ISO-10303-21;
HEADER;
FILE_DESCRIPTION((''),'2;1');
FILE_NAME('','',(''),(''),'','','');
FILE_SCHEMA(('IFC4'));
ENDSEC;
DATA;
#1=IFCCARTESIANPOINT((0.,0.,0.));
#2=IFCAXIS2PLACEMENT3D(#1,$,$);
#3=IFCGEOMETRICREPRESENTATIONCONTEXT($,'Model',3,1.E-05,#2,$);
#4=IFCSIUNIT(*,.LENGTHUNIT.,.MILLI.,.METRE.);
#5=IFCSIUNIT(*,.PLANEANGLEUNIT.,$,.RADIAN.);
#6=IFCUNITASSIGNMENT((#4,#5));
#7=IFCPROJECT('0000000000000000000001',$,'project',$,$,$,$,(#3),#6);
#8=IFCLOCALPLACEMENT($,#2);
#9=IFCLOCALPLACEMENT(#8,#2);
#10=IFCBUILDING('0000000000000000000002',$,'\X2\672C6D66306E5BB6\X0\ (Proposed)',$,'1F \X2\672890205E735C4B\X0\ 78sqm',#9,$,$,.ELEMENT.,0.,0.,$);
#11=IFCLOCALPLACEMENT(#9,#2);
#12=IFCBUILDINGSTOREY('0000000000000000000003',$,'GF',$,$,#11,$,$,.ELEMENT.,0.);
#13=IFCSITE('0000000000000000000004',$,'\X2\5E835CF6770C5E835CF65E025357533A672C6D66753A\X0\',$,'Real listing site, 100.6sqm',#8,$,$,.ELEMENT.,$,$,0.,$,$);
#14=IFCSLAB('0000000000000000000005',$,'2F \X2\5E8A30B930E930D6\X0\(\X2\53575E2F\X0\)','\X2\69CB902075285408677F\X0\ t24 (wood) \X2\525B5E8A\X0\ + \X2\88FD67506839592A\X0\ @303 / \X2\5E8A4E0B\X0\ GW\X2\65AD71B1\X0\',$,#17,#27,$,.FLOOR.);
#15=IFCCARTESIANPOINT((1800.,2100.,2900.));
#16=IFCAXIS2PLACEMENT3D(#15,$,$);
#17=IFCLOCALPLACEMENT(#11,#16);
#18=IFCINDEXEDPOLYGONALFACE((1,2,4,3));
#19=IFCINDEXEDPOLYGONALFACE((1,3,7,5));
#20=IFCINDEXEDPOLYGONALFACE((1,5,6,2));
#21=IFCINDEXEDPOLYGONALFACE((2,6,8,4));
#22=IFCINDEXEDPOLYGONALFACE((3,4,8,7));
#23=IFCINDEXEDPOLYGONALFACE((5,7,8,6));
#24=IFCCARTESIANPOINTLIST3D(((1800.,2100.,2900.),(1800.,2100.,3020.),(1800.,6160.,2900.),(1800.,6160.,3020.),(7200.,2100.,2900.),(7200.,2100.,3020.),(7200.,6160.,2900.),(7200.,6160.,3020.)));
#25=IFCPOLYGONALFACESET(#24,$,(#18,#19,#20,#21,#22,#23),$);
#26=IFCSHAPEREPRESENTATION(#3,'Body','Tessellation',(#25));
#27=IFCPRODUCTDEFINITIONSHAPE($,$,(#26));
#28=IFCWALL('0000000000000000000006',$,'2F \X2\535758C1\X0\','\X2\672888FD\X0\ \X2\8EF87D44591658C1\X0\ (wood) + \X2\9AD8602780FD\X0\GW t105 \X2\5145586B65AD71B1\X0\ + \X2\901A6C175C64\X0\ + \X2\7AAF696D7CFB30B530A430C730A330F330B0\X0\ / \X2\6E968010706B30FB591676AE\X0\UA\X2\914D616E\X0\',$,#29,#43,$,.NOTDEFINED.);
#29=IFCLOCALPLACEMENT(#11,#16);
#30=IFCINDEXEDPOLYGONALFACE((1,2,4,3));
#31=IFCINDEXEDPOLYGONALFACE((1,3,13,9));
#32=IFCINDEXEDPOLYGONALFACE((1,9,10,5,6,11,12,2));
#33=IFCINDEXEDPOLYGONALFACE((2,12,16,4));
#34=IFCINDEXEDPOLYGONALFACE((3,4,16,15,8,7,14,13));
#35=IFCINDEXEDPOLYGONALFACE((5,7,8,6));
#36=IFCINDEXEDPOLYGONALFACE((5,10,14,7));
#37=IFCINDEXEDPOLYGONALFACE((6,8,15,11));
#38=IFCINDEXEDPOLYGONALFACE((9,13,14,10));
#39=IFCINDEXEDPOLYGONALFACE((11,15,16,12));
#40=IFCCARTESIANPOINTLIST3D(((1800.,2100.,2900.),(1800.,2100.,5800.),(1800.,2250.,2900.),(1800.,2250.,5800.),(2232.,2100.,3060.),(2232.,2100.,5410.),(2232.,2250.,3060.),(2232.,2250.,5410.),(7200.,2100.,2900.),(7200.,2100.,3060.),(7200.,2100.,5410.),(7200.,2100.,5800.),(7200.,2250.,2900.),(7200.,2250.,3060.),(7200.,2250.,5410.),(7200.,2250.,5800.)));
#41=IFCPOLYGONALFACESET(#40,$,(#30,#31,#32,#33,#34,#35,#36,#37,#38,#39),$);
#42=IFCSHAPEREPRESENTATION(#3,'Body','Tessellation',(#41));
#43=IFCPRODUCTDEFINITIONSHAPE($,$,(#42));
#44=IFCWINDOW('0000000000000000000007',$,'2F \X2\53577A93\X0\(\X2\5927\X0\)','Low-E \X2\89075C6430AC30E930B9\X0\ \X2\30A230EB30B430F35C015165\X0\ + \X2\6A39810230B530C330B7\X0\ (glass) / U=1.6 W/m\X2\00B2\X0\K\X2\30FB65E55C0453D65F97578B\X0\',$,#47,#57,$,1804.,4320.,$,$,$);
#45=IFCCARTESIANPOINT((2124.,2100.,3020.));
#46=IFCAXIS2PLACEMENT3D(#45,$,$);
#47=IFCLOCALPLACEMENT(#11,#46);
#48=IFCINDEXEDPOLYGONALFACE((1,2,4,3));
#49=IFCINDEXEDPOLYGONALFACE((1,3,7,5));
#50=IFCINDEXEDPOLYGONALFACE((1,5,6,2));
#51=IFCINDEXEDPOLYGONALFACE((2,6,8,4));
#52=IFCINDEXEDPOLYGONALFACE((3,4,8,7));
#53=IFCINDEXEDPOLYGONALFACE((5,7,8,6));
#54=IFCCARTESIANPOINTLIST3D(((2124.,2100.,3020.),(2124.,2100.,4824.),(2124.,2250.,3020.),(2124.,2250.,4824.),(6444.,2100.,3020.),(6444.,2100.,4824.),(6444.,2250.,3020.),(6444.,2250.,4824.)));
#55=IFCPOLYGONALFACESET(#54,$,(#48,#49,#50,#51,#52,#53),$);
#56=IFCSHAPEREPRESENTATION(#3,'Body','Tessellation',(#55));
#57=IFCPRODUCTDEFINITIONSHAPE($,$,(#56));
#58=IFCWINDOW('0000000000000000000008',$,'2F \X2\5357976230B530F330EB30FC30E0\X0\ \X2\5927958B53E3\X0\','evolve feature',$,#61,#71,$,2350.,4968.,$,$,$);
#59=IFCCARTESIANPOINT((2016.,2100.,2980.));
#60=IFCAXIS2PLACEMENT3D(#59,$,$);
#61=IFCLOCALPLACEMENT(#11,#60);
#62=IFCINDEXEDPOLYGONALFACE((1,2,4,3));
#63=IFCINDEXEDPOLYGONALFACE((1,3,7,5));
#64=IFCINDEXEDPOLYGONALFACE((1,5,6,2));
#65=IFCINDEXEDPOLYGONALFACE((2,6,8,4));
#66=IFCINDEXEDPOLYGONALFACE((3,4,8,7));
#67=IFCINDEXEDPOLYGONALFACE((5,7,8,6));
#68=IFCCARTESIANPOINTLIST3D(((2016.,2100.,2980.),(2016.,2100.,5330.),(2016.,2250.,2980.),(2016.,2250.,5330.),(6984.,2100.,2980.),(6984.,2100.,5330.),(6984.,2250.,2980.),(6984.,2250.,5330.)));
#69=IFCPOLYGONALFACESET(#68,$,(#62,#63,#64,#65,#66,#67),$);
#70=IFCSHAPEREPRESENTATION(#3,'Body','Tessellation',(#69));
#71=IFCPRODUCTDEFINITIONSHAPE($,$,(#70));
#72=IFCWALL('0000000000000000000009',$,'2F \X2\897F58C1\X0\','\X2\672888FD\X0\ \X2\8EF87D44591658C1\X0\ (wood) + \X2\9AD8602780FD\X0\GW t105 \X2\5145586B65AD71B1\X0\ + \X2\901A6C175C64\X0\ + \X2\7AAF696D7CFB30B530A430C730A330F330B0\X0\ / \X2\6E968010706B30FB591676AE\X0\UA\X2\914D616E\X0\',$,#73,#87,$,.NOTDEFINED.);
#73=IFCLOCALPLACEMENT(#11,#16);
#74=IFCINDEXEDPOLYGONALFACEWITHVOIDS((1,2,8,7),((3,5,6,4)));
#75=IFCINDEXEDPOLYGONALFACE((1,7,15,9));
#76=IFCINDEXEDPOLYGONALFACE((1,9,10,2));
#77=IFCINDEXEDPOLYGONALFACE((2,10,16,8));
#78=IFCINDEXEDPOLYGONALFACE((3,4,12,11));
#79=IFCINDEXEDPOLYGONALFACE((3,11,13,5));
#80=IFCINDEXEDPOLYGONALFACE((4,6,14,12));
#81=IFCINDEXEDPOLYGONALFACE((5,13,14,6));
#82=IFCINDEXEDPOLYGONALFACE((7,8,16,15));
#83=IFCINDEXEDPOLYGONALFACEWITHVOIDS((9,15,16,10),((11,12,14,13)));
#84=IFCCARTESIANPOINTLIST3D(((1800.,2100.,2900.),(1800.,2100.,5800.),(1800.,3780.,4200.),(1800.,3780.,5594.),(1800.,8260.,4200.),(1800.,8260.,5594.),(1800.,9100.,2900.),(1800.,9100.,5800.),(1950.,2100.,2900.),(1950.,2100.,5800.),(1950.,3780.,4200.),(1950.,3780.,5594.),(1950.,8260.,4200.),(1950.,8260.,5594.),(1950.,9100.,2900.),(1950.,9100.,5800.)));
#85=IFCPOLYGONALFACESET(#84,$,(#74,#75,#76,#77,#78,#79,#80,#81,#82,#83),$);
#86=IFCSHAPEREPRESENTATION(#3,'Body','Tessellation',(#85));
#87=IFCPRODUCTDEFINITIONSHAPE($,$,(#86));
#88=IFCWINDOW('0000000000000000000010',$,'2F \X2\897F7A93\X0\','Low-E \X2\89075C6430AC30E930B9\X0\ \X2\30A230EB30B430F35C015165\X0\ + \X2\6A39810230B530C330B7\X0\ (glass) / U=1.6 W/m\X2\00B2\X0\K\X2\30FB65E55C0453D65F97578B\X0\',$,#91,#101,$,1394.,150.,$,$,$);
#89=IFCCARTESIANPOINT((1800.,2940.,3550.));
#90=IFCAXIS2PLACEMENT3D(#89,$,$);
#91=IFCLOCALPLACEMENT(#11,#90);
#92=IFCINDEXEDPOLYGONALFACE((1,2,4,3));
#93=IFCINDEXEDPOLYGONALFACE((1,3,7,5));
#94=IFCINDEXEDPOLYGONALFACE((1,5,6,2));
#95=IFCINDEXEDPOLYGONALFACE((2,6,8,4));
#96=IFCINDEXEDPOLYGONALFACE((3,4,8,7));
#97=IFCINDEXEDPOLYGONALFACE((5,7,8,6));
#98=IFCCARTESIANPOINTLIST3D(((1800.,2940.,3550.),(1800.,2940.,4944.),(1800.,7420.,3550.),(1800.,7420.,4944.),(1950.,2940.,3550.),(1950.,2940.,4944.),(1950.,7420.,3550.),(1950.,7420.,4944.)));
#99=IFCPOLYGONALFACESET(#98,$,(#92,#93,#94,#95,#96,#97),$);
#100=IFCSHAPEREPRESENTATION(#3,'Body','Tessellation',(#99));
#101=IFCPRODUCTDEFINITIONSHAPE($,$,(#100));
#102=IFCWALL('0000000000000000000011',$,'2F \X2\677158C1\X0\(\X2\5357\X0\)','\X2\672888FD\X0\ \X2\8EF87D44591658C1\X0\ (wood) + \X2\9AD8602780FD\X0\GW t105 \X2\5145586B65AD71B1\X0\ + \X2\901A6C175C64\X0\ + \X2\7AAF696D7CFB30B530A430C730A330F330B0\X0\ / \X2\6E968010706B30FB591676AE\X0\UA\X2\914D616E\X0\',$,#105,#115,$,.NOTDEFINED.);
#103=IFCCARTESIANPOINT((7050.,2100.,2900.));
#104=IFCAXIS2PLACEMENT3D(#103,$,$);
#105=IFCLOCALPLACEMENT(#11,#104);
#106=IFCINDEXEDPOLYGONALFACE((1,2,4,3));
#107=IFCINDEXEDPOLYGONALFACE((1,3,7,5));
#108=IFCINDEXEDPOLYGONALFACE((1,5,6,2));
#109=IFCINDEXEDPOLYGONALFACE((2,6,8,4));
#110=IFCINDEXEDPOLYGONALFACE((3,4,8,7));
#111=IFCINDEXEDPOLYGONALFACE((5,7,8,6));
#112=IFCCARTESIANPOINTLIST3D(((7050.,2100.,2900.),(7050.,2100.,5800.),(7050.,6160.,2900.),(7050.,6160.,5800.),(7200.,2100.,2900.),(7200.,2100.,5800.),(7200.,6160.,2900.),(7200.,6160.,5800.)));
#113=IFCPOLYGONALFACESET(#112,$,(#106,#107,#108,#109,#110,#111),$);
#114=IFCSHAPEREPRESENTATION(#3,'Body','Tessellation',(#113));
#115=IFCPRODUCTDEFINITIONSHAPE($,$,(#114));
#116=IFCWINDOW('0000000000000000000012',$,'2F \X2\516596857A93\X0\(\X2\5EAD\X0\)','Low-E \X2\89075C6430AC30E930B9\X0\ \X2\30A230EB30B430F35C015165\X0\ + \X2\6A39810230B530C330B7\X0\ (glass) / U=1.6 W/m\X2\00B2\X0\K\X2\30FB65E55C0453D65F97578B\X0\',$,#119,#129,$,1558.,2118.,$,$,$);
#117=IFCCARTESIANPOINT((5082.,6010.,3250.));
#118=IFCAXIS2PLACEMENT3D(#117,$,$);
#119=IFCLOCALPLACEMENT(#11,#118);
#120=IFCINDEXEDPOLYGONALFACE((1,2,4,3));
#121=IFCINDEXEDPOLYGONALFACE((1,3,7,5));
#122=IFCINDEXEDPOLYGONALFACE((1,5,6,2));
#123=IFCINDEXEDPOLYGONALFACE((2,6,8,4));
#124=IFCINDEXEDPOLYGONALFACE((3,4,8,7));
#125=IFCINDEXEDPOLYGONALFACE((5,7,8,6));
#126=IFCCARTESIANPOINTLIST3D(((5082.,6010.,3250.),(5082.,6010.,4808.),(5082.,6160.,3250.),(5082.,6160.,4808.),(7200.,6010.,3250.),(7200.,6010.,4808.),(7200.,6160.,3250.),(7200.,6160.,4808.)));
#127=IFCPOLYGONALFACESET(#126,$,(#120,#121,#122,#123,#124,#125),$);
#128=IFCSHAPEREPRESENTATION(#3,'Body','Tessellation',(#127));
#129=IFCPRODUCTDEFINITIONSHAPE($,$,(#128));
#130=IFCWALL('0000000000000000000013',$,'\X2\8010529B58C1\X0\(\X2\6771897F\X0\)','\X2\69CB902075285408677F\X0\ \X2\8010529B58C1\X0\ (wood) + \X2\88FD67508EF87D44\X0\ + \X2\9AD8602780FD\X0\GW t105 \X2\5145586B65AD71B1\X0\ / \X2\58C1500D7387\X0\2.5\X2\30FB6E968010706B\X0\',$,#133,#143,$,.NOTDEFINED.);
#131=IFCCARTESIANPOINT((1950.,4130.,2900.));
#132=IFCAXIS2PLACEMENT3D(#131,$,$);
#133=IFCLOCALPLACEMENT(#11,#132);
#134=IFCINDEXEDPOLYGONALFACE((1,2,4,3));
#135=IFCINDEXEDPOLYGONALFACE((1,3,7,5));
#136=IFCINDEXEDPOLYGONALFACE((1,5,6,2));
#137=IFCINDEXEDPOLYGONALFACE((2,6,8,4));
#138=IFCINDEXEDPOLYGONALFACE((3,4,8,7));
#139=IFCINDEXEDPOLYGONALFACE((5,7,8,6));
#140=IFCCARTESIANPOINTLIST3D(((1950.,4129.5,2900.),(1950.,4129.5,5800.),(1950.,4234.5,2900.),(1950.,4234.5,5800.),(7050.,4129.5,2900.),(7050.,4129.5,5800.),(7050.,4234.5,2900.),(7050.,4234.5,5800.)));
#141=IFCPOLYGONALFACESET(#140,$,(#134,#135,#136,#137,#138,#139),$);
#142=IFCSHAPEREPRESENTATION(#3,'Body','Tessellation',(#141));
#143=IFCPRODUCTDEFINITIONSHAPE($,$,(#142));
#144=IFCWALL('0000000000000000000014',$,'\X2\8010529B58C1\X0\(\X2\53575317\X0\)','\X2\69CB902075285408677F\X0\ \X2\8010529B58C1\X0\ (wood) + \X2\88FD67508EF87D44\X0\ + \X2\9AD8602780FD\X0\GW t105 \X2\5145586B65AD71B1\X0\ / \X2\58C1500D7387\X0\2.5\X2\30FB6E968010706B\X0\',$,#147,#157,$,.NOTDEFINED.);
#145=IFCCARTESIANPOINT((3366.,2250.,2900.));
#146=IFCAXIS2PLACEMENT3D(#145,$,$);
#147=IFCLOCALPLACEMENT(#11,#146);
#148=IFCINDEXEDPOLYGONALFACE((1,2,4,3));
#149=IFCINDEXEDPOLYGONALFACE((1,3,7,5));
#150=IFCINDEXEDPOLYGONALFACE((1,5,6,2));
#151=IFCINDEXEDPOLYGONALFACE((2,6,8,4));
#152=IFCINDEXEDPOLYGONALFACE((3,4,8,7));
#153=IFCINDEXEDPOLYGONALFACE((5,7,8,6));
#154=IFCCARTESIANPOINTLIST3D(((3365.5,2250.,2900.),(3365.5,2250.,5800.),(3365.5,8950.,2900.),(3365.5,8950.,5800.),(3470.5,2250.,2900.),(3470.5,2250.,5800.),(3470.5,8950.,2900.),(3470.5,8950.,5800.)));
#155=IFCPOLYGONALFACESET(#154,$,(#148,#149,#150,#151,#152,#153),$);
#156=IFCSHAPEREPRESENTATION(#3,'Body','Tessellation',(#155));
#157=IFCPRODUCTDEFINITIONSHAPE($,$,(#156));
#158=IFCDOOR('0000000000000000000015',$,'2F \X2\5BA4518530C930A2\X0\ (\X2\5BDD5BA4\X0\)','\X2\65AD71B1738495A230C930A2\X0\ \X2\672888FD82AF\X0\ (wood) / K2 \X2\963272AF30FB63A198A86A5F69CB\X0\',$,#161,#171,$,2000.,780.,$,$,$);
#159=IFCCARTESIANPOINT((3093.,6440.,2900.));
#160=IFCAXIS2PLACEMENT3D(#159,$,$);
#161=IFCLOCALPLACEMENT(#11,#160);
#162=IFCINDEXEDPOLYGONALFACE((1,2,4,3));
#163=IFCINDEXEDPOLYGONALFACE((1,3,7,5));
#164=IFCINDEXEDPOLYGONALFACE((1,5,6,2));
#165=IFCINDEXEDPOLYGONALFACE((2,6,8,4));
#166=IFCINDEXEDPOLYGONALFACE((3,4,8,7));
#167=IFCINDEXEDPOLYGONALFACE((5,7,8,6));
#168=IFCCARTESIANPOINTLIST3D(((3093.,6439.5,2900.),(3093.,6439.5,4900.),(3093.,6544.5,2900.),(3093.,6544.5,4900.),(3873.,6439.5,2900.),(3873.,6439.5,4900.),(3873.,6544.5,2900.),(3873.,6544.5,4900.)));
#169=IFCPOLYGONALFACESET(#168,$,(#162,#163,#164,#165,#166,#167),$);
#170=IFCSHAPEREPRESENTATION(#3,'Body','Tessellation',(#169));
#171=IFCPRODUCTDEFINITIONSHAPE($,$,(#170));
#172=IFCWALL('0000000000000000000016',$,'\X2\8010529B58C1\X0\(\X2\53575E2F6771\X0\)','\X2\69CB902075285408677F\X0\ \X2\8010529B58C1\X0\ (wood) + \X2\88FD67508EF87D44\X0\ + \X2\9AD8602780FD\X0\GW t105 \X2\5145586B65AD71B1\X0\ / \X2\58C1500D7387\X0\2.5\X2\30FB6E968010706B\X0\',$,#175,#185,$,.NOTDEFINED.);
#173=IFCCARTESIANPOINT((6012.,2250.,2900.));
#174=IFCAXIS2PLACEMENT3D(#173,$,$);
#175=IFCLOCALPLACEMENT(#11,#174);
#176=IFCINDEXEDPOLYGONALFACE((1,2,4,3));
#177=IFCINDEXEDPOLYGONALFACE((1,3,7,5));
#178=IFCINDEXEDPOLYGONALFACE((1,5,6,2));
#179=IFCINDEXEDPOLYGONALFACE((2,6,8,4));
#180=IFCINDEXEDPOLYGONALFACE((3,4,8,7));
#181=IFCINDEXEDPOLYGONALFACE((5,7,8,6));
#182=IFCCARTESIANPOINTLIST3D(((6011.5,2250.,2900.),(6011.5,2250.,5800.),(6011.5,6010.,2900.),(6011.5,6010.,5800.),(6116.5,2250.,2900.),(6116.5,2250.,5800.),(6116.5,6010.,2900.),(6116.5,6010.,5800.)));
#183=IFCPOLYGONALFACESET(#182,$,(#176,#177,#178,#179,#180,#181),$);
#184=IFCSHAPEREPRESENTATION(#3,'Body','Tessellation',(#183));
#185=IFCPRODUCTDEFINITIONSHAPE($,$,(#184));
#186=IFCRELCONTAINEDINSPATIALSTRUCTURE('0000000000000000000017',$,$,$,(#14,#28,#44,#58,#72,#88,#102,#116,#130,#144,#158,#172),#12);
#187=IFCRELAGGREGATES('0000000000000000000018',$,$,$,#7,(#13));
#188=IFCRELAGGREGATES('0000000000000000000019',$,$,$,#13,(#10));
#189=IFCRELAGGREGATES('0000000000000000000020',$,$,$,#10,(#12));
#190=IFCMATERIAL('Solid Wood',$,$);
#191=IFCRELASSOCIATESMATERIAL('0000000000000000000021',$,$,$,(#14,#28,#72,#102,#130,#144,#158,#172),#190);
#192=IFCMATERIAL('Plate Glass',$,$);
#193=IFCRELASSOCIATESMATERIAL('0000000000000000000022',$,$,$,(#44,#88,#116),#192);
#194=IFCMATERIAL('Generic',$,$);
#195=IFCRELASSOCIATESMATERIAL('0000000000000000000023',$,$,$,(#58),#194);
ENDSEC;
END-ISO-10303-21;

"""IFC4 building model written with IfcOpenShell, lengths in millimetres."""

from ifc_helpers import new_model, si_unit, frame, frame_2d, origin, place, context, project, spatial, rectangle, extrude, material, element, fill, save


model = new_model("IFC4")

# Units and contexts
model_context = context("Model", 3, precision=1e-05, world=origin())
ifc_project = project(units=[si_unit("LENGTHUNIT", "METRE", prefix="MILLI"), si_unit("PLANEANGLEUNIT", "RADIAN")], contexts=[model_context])

# Site, building, storey
site_placement = place(None, origin())
site = spatial("IfcSite", under=ifc_project, at=site_placement, Name="広島県広島市南区本浦町", ObjectType="Real listing site, 100.6sqm", CompositionType="ELEMENT", RefElevation=0.0)
building_placement = place(site_placement, origin())
building = spatial("IfcBuilding", under=site, at=building_placement, Name="本浦の家 (Proposed)", ObjectType="1F 木造平屋 78sqm", CompositionType="ELEMENT", ElevationOfRefHeight=0.0, ElevationOfTerrain=0.0)
storey_placement = place(building_placement, origin())
storey = spatial("IfcBuildingStorey", under=building, at=storey_placement, Name="GF", CompositionType="ELEMENT", Elevation=0.0)

# Slab
ifc_material_1 = material(Name="Solid Wood")
slab_placement = place(storey_placement, frame((1800.0, 2100.0, 2900.0)))
element("IfcSlab", 1, at=slab_placement, inside=storey, material=ifc_material_1, Name="2F 床スラブ(南帯)", Description="構造用合板 t24 (wood) 剛床 + 製材根太 @303 / 床下 GW断熱", PredefinedType="FLOOR", context=model_context, shape_type="SweptSolid", body=[
    extrude(rectangle(XDim=5400.0, YDim=4060.0, at=frame_2d((2700.0, 2030.0))), frame((1800.0, 2100.0, 2900.0)), (0.0, 0.0, 1.0), 120.0),
])

# Wall, openings, windows
wall_1_placement = place(storey_placement, frame((1800.0, 2100.0, 2900.0)))
wall_1 = element("IfcWall", 2, at=wall_1_placement, inside=storey, material=ifc_material_1, Name="2F 南壁", Description="木製 軸組外壁 (wood) + 高性能GW t105 充填断熱 + 通気層 + 窯業系サイディング / 準耐火・外皮UA配慮", PredefinedType="NOTDEFINED", context=model_context, shape_type="SweptSolid", body=[
    extrude(rectangle(XDim=5400.0, YDim=150.0, at=frame_2d((2700.0, 75.0))), frame((1800.0, 2100.0, 2900.0)), (0.0, 0.0, 1.0), 2900.0),
])
opening_1_placement = place(storey_placement, frame((2124.0, 2100.0, 3020.0)))
opening_1 = element("IfcOpeningElement", 3, at=opening_1_placement, cuts=wall_1, PredefinedType="NOTDEFINED", context=model_context, shape_type="SweptSolid", body=[
    extrude(rectangle(XDim=4320.0, YDim=150.0, at=frame_2d((2160.0, 75.0))), frame((2124.0, 2100.0, 3020.0)), (0.0, 0.0, 1.0), 1804.0),
])
opening_2_placement = place(storey_placement, frame((2016.0, 2100.0, 2980.0)))
opening_2 = element("IfcOpeningElement", 4, at=opening_2_placement, cuts=wall_1, PredefinedType="NOTDEFINED", context=model_context, shape_type="SweptSolid", body=[
    extrude(rectangle(XDim=4968.0, YDim=150.0, at=frame_2d((2484.0, 75.0))), frame((2016.0, 2100.0, 2980.0)), (0.0, 0.0, 1.0), 2350.0),
])
ifc_material_2 = material(Name="Plate Glass")
window_1_placement = place(storey_placement, frame((2124.0, 2100.0, 3020.0)))
window_1 = element("IfcWindow", 5, at=window_1_placement, inside=storey, material=ifc_material_2, Name="2F 南窓(大)", Description="Low-E 複層ガラス アルゴン封入 + 樹脂サッシ (glass) / U=1.6 W/m²K・日射取得型", OverallHeight=1804.0, OverallWidth=4320.0, context=model_context, shape_type="SweptSolid", body=[
    extrude(rectangle(XDim=4320.0, YDim=150.0, at=frame_2d((2160.0, 75.0))), frame((2124.0, 2100.0, 3020.0)), (0.0, 0.0, 1.0), 1804.0),
])
fill(opening_1, window_1)
ifc_material_3 = material(Name="Generic")
window_2_placement = place(storey_placement, frame((2016.0, 2100.0, 2980.0)))
window_2 = element("IfcWindow", 6, at=window_2_placement, inside=storey, material=ifc_material_3, Name="2F 南面サンルーム 大開口", Description="evolve feature", OverallHeight=2350.0, OverallWidth=4968.0, context=model_context, shape_type="SweptSolid", body=[
    extrude(rectangle(XDim=4968.0, YDim=150.0, at=frame_2d((2484.0, 75.0))), frame((2016.0, 2100.0, 2980.0)), (0.0, 0.0, 1.0), 2350.0),
])
fill(opening_2, window_2)

# Walls, openings, windows
wall_2_placement = place(storey_placement, frame((1800.0, 2100.0, 2900.0)))
wall_2 = element("IfcWall", 7, at=wall_2_placement, inside=storey, material=ifc_material_1, Name="2F 西壁", Description="木製 軸組外壁 (wood) + 高性能GW t105 充填断熱 + 通気層 + 窯業系サイディング / 準耐火・外皮UA配慮", PredefinedType="NOTDEFINED", context=model_context, shape_type="SweptSolid", body=[
    extrude(rectangle(XDim=150.0, YDim=7000.0, at=frame_2d((75.0, 3500.0))), frame((1800.0, 2100.0, 2900.0)), (0.0, 0.0, 1.0), 2900.0),
])
opening_3_placement = place(storey_placement, frame((1800.0, 2940.0, 3550.0)))
opening_3 = element("IfcOpeningElement", 8, at=opening_3_placement, cuts=wall_2, PredefinedType="NOTDEFINED", context=model_context, shape_type="SweptSolid", body=[
    extrude(rectangle(XDim=150.0, YDim=4480.0, at=frame_2d((75.0, 2240.0))), frame((1800.0, 2940.0, 3550.0)), (0.0, 0.0, 1.0), 1394.0),
])
window_3_placement = place(storey_placement, frame((1800.0, 2940.0, 3550.0)))
window_3 = element("IfcWindow", 9, at=window_3_placement, inside=storey, material=ifc_material_2, Name="2F 西窓", Description="Low-E 複層ガラス アルゴン封入 + 樹脂サッシ (glass) / U=1.6 W/m²K・日射取得型", OverallHeight=1394.0, OverallWidth=150.0, context=model_context, shape_type="SweptSolid", body=[
    extrude(rectangle(XDim=150.0, YDim=4480.0, at=frame_2d((75.0, 2240.0))), frame((1800.0, 2940.0, 3550.0)), (0.0, 0.0, 1.0), 1394.0),
])
fill(opening_3, window_3)
wall_3_placement = place(storey_placement, frame((7050.0, 2100.0, 2900.0)))
wall_3 = element("IfcWall", 10, at=wall_3_placement, inside=storey, material=ifc_material_1, Name="2F 東壁(南)", Description="木製 軸組外壁 (wood) + 高性能GW t105 充填断熱 + 通気層 + 窯業系サイディング / 準耐火・外皮UA配慮", PredefinedType="NOTDEFINED", context=model_context, shape_type="SweptSolid", body=[
    extrude(rectangle(XDim=150.0, YDim=4060.0, at=frame_2d((75.0, 2030.0))), frame((7050.0, 2100.0, 2900.0)), (0.0, 0.0, 1.0), 2900.0),
])
opening_4_placement = place(storey_placement, frame((5082.0, 6010.0, 3250.0)))
opening_4 = element("IfcOpeningElement", 11, at=opening_4_placement, cuts=wall_3, PredefinedType="NOTDEFINED", context=model_context, shape_type="SweptSolid", body=[
    extrude(rectangle(XDim=2118.0, YDim=150.0, at=frame_2d((1059.0, 75.0))), frame((5082.0, 6010.0, 3250.0)), (0.0, 0.0, 1.0), 1558.0),
])
window_4_placement = place(storey_placement, frame((5082.0, 6010.0, 3250.0)))
window_4 = element("IfcWindow", 12, at=window_4_placement, inside=storey, material=ifc_material_2, Name="2F 入隅窓(庭)", Description="Low-E 複層ガラス アルゴン封入 + 樹脂サッシ (glass) / U=1.6 W/m²K・日射取得型", OverallHeight=1558.0, OverallWidth=2118.0, context=model_context, shape_type="SweptSolid", body=[
    extrude(rectangle(XDim=2118.0, YDim=150.0, at=frame_2d((1059.0, 75.0))), frame((5082.0, 6010.0, 3250.0)), (0.0, 0.0, 1.0), 1558.0),
])
fill(opening_4, window_4)

# Wall
wall_4_placement = place(storey_placement, frame((1950.0, 4130.0, 2900.0)))
element("IfcWall", 13, at=wall_4_placement, inside=storey, material=ifc_material_1, Name="耐力壁(東西)", Description="構造用合板 耐力壁 (wood) + 製材軸組 + 高性能GW t105 充填断熱 / 壁倍率2.5・準耐火", PredefinedType="NOTDEFINED", context=model_context, shape_type="SweptSolid", body=[
    extrude(rectangle(XDim=5100.0, YDim=105.0, at=frame_2d((2550.0, 52.0))), frame((1950.0, 4130.0, 2900.0)), (0.0, 0.0, 1.0), 2900.0),
])

# Wall, opening, door
wall_5_placement = place(storey_placement, frame((3366.0, 2250.0, 2900.0)))
wall_5 = element("IfcWall", 14, at=wall_5_placement, inside=storey, material=ifc_material_1, Name="耐力壁(南北)", Description="構造用合板 耐力壁 (wood) + 製材軸組 + 高性能GW t105 充填断熱 / 壁倍率2.5・準耐火", PredefinedType="NOTDEFINED", context=model_context, shape_type="SweptSolid", body=[
    extrude(rectangle(XDim=105.0, YDim=6700.0, at=frame_2d((52.0, 3350.0))), frame((3366.0, 2250.0, 2900.0)), (0.0, 0.0, 1.0), 2900.0),
])
opening_5_placement = place(storey_placement, frame((3093.0, 6440.0, 2900.0)))
opening_5 = element("IfcOpeningElement", 15, at=opening_5_placement, cuts=wall_5, PredefinedType="NOTDEFINED", context=model_context, shape_type="SweptSolid", body=[
    extrude(rectangle(XDim=780.0, YDim=105.0, at=frame_2d((390.0, 52.0))), frame((3093.0, 6440.0, 2900.0)), (0.0, 0.0, 1.0), 2000.0),
])
door_placement = place(storey_placement, frame((3093.0, 6440.0, 2900.0)))
door = element("IfcDoor", 16, at=door_placement, inside=storey, material=ifc_material_1, Name="2F 室内ドア (寝室)", Description="断熱玄関ドア 木製芯 (wood) / K2 防犯・採風機構", OverallHeight=2000.0, OverallWidth=780.0, context=model_context, shape_type="SweptSolid", body=[
    extrude(rectangle(XDim=780.0, YDim=105.0, at=frame_2d((390.0, 52.0))), frame((3093.0, 6440.0, 2900.0)), (0.0, 0.0, 1.0), 2000.0),
])
fill(opening_5, door)

# Wall
wall_6_placement = place(storey_placement, frame((6012.0, 2250.0, 2900.0)))
element("IfcWall", 17, at=wall_6_placement, inside=storey, material=ifc_material_1, Name="耐力壁(南帯東)", Description="構造用合板 耐力壁 (wood) + 製材軸組 + 高性能GW t105 充填断熱 / 壁倍率2.5・準耐火", PredefinedType="NOTDEFINED", context=model_context, shape_type="SweptSolid", body=[
    extrude(rectangle(XDim=105.0, YDim=3760.0, at=frame_2d((52.0, 1880.0))), frame((6012.0, 2250.0, 2900.0)), (0.0, 0.0, 1.0), 2900.0),
])

save(model, "model.ifc")
